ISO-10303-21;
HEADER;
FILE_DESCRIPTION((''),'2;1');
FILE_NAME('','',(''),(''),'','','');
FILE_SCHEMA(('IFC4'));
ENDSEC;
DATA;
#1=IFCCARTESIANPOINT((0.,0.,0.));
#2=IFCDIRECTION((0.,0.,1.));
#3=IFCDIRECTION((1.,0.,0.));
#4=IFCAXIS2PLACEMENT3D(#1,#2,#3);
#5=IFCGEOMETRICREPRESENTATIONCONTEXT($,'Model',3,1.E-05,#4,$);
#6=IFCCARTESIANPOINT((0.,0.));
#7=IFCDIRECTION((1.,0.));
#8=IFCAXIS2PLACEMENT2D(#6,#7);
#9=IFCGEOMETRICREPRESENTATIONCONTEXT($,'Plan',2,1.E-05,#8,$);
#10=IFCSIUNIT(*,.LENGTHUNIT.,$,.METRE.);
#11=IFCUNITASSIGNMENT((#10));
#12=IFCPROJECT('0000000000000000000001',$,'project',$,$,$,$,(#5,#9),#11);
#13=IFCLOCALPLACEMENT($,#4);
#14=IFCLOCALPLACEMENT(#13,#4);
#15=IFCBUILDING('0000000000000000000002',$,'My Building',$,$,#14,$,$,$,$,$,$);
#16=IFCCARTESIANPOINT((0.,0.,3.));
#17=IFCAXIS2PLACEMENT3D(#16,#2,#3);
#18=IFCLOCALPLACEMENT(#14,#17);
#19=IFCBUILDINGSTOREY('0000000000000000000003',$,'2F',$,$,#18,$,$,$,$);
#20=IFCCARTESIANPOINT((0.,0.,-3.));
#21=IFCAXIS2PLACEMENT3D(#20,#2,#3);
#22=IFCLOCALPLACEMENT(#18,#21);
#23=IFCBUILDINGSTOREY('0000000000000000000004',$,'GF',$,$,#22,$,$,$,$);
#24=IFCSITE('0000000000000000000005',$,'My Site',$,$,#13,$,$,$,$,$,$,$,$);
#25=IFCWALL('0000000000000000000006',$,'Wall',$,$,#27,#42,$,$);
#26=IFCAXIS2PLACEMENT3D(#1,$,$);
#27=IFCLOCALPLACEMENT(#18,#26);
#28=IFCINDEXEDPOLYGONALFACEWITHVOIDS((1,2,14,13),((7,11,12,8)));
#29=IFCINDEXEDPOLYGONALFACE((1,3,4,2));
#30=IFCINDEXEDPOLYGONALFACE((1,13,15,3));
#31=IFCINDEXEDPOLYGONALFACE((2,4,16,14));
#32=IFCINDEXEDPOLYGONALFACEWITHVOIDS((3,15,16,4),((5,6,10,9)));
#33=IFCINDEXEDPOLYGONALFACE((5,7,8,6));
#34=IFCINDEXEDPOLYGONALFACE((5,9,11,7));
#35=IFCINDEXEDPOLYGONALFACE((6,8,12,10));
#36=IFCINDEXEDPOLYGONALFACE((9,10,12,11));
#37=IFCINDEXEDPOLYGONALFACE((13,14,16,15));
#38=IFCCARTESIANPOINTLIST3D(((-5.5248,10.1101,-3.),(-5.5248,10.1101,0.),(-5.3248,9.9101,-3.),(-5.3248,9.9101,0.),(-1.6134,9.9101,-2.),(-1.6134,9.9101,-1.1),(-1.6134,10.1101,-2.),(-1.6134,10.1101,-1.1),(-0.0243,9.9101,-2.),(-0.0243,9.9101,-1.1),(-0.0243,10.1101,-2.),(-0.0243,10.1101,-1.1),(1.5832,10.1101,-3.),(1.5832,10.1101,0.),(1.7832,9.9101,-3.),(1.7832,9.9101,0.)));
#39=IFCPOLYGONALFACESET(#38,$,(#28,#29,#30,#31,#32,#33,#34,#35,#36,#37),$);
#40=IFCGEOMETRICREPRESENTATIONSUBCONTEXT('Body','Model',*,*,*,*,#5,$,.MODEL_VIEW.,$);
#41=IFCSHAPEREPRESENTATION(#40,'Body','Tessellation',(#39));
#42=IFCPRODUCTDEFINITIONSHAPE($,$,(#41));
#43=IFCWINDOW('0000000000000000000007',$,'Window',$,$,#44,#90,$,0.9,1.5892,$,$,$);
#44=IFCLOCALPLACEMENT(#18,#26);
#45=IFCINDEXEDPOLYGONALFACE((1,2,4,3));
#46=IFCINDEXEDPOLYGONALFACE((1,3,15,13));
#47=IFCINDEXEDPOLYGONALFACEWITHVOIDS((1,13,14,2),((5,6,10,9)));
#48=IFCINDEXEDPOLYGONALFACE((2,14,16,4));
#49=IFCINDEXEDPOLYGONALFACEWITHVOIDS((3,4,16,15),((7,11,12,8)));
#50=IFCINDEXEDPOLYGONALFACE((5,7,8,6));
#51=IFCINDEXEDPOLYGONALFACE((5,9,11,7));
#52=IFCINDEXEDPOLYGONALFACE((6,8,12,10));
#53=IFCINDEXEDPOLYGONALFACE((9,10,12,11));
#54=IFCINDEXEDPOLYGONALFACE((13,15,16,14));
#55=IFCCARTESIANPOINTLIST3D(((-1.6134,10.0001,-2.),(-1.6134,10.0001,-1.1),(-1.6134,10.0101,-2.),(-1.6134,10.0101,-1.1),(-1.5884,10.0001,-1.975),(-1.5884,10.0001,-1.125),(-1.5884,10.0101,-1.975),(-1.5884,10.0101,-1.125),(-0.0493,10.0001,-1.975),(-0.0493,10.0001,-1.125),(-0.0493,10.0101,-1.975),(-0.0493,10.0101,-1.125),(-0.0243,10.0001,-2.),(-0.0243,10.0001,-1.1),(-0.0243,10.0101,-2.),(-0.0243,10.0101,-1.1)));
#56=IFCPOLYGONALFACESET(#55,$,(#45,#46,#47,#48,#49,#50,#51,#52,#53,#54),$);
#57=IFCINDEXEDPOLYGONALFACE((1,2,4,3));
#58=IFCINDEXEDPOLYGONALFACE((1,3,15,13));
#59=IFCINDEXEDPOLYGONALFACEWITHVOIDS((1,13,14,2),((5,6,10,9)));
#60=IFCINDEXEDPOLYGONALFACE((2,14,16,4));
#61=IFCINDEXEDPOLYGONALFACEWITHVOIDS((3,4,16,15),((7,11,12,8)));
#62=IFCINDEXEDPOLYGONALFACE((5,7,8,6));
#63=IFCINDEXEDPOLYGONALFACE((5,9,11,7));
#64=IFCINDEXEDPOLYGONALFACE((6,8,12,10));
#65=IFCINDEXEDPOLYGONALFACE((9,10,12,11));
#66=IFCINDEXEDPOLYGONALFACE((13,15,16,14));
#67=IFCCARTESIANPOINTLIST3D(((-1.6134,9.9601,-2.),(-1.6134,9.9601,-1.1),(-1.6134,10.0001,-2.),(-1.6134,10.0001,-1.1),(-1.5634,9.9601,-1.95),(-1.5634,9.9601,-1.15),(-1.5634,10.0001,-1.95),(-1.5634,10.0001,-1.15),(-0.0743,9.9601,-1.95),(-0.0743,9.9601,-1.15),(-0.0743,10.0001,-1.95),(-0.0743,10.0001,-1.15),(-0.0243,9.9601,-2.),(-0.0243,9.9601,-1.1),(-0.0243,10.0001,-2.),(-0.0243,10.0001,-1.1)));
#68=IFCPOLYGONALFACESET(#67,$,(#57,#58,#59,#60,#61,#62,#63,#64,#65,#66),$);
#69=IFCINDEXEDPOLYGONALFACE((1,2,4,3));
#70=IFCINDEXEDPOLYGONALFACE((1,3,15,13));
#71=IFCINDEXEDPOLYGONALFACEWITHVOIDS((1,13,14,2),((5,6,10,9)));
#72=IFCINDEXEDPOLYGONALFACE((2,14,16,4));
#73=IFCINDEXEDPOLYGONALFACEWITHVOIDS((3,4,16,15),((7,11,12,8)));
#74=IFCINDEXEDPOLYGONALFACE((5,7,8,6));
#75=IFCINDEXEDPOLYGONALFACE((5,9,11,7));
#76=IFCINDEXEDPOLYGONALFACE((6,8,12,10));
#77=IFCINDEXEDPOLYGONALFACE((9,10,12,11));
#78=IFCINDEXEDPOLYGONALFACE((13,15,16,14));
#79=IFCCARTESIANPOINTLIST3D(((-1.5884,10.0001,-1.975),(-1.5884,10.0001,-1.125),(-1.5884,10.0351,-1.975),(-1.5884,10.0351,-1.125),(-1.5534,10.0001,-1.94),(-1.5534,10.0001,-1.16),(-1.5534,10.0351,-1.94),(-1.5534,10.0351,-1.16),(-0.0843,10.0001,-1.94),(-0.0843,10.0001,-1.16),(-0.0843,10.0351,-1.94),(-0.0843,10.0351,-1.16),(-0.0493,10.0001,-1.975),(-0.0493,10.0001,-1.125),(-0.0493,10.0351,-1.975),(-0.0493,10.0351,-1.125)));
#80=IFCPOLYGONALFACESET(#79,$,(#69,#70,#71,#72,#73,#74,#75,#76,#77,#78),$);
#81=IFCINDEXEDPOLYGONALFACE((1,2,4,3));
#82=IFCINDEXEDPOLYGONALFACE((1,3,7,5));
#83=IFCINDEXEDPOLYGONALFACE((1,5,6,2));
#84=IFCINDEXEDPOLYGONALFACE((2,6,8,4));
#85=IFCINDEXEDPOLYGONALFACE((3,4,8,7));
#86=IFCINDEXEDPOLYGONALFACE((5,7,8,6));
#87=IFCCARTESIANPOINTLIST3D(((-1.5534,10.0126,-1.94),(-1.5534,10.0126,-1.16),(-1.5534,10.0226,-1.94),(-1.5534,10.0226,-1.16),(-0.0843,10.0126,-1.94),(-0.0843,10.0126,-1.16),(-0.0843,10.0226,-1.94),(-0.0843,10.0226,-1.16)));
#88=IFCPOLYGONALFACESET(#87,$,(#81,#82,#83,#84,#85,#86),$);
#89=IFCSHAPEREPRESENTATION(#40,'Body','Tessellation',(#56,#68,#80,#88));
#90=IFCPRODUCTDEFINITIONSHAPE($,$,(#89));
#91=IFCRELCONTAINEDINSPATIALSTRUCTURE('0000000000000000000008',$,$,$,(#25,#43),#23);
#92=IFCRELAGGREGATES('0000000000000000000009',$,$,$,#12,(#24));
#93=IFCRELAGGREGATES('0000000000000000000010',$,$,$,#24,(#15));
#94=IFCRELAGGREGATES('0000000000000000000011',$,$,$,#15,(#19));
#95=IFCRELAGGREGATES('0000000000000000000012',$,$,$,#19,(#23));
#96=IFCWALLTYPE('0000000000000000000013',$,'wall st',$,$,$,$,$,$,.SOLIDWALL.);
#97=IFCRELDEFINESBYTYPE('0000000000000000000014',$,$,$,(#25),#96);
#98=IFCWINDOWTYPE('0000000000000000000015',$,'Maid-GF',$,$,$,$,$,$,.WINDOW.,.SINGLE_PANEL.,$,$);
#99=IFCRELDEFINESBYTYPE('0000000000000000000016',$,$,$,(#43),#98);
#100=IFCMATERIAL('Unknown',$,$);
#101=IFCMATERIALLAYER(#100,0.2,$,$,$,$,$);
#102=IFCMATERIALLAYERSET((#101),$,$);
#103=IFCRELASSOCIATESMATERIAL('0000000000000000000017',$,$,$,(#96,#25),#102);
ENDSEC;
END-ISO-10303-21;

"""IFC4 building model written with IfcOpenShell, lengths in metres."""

from ifc_helpers import new_model, entity, si_unit, frame, origin_with_axes, origin_2d_with_axis, place, context, subcontext, project, spatial, line, indexed_curve, outline, extrude, shape, source, transform, mapped, material, layer, layer_set, layer_usage, type_object, type_shapes, element, fill, save


model = new_model("IFC4")

# Units and contexts
model_context = context("Model", 3, precision=1e-05, world=origin_with_axes())
plan_context = context("Plan", 2, precision=1e-05, world=origin_2d_with_axis())
body_context_1 = subcontext(model_context, "Body", "Model", "MODEL_VIEW")
body_context_2 = subcontext(plan_context, "Body", "Plan", "PLAN_VIEW")
ifc_project = project(units=[si_unit("LENGTHUNIT", "METRE")], contexts=[model_context, plan_context])

# Site, building, storeys
site_placement = place(None, origin_with_axes())
site = spatial("IfcSite", under=ifc_project, at=site_placement, Name="My Site")
building_placement = place(site_placement, origin_with_axes())
building = spatial("IfcBuilding", under=site, at=building_placement, Name="My Building")
storey_1_placement = place(building_placement, frame((0.0, 0.0, 3.0), z_axis=(0.0, 0.0, 1.0), x_axis=(1.0, 0.0, 0.0)))
storey_1 = spatial("IfcBuildingStorey", under=building, at=storey_1_placement, Name="2F")
storey_2_placement = place(storey_1_placement, frame((0.0, 0.0, -3.0), z_axis=(0.0, 0.0, 1.0), x_axis=(1.0, 0.0, 0.0)))
storey_2 = spatial("IfcBuildingStorey", under=storey_1, at=storey_2_placement, Name="GF")

# Shared definitions
ifc_material = material(Name="Unknown")

# Shared definitions
ifc_layer = layer(ifc_material, 0.2)
ifc_layer_set = layer_set([ifc_layer])
wall_type = type_object("IfcWallType", Name="wall st", PredefinedType="SOLIDWALL", material=ifc_layer_set)

# Wall, opening, window
ifc_layer_usage_1 = layer_usage(ifc_layer_set, "AXIS2", "POSITIVE", 0.0)
wall_1_placement = place(storey_2_placement, frame((1.5832, 10.1101, 0.0), z_axis=(0.0, 0.0, 1.0), x_axis=(-1.0, 0.0, 0.0)))
wall_1 = element("IfcWall", 1, at=wall_1_placement, inside=storey_2, type_object=wall_type, material=ifc_layer_usage_1, Name="Wall", context=body_context_1, shape_type="SweptSolid", body=[
    extrude(outline(indexed_curve([(0.0, 0.0), (-0.2, 0.2), (6.908, 0.2), (7.108, 0.0)], segments=[line(1, 2, 3, 4, 1)])), origin_with_axes(), (0.0, 0.0, 1.0), 3.0),
])
shared_shape_1 = source(origin_with_axes(), body_context_1, "Body", "SweptSolid", [
    extrude(outline(indexed_curve([(0.0, 0.0), (1.5892, 0.0), (1.5892, 0.9), (0.0, 0.9)], segments=[line(1, 2, 3, 4, 1)])), frame((0.0, -0.6, 0.0), z_axis=(0.0, -1.0, 0.0), x_axis=(1.0, 0.0, 0.0)), (0.0, 0.0, -1.0), 1.2),
])
opening_1_placement = place(wall_1_placement, frame((3.1967, 0.2, 1.0), z_axis=(0.0, 0.0, 1.0), x_axis=(-1.0, 0.0, 0.0)))
opening_1 = element("IfcOpeningElement", 2, at=opening_1_placement, cuts=wall_1, PredefinedType="OPENING", context=body_context_1, shape_type="MappedRepresentation", body=[
    mapped(shared_shape_1, transform((0.0, 0.0, 0.0), x_axis=(1.0, 0.0, 0.0), y_axis=(0.0, 1.0, 0.0), z_axis=(0.0, 0.0, 1.0), scale=1.0)),
])
window_type_1 = type_object("IfcWindowType", Name="Maid-GF", PartitioningType="SINGLE_PANEL", PredefinedType="WINDOW")
shared_shape_2 = source(origin_with_axes(), body_context_1, "Body", "SweptSolid", [
    extrude(outline(indexed_curve([(0.0, 0.0), (1.5892, 0.0), (1.5892, 0.9), (0.0, 0.9)], segments=[line(1, 2, 3, 4, 1)]), holes=[indexed_curve([(0.025, 0.025), (1.5642, 0.025), (1.5642, 0.875), (0.025, 0.875)], segments=[line(1, 2, 3, 4, 1)])]), frame((0.0, 0.09, 0.0), z_axis=(0.0, -1.0, 0.0), x_axis=(1.0, 0.0, 0.0)), (0.0, 0.0, -1.0), 0.01),
    extrude(outline(indexed_curve([(0.0, 0.0), (1.5892, 0.0), (1.5892, 0.9), (0.0, 0.9)], segments=[line(1, 2, 3, 4, 1)]), holes=[indexed_curve([(0.05, 0.05), (1.5392, 0.05), (1.5392, 0.85), (0.05, 0.85)], segments=[line(1, 2, 3, 4, 1)])]), frame((0.0, 0.05, 0.0), z_axis=(0.0, -1.0, 0.0), x_axis=(1.0, 0.0, 0.0)), (0.0, 0.0, -1.0), 0.04),
    extrude(outline(indexed_curve([(0.0, 0.0), (1.5392, 0.0), (1.5392, 0.85), (0.0, 0.85)], segments=[line(1, 2, 3, 4, 1)]), holes=[indexed_curve([(0.035, 0.035), (1.5042, 0.035), (1.5042, 0.815), (0.035, 0.815)], segments=[line(1, 2, 3, 4, 1)])]), frame((0.025, 0.09, 0.025), z_axis=(0.0, -1.0, 0.0), x_axis=(1.0, 0.0, 0.0)), (0.0, 0.0, -1.0), 0.035),
    extrude(outline(indexed_curve([(0.035, 0.035), (1.5042, 0.035), (1.5042, 0.815), (0.035, 0.815)], segments=[line(1, 2, 3, 4, 1)])), frame((0.025, 0.1025, 0.025), z_axis=(0.0, -1.0, 0.0), x_axis=(1.0, 0.0, 0.0)), (0.0, 0.0, -1.0), 0.01),
])
shared_shape_3 = source(origin_with_axes(), body_context_2, "Body", "Curve2D", [
    entity("IfcIndexedPolyCurve", entity("IfcCartesianPointList2D", [[0.05, 0.05], [1.5392, 0.05]])),
    entity("IfcIndexedPolyCurve", entity("IfcCartesianPointList2D", [[0.0, 0.1], [0.025, 0.1], [0.025, 0.09], [0.05, 0.09], [0.05, 0.05], [0.0, 0.05]]), [entity("IfcLineIndex", [1, 2, 3, 4, 5, 6, 1])]),
    entity("IfcIndexedPolyCurve", entity("IfcCartesianPointList2D", [[1.5892, 0.1], [1.5642, 0.1], [1.5642, 0.09], [1.5392, 0.09], [1.5392, 0.05], [1.5892, 0.05]]), [entity("IfcLineIndex", [1, 2, 3, 4, 5, 6, 1])]),
    entity("IfcIndexedPolyCurve", entity("IfcCartesianPointList2D", [[0.025, 0.09], [0.06, 0.09], [0.06, 0.125], [0.025, 0.125]]), [entity("IfcLineIndex", [1, 2, 3, 4, 1])]),
    entity("IfcIndexedPolyCurve", entity("IfcCartesianPointList2D", [[1.5642, 0.09], [1.5292, 0.09], [1.5292, 0.125], [1.5642, 0.125]]), [entity("IfcLineIndex", [1, 2, 3, 4, 1])]),
    entity("IfcIndexedPolyCurve", entity("IfcCartesianPointList2D", [[0.06, 0.09], [1.5292, 0.09]])),
    entity("IfcIndexedPolyCurve", entity("IfcCartesianPointList2D", [[0.06, 0.125], [1.5292, 0.125]])),
    entity("IfcIndexedPolyCurve", entity("IfcCartesianPointList2D", [[0.06, 0.1075], [1.5292, 0.1075]])),
])
type_shapes(window_type_1, [shared_shape_2, shared_shape_3])
window_1_placement = place(opening_1_placement, frame((0.0, 0.0, 0.0), z_axis=(0.0, 0.0, 1.0), x_axis=(1.0, 0.0, 0.0)))
window_1 = element("IfcWindow", 3, at=window_1_placement, inside=storey_2, type_object=window_type_1, Name="Window", OverallHeight=0.9, OverallWidth=1.5892, shapes=[
    shape(body_context_1, "Body", "MappedRepresentation", [mapped(shared_shape_2, transform((0.0, 0.0, 0.0), x_axis=(1.0, 0.0, 0.0), y_axis=(0.0, 1.0, 0.0), z_axis=(0.0, 0.0, 1.0), scale=1.0))]),
    shape(body_context_2, "Body", "MappedRepresentation", [mapped(shared_shape_3, transform((0.0, 0.0, 0.0), x_axis=(1.0, 0.0, 0.0), y_axis=(0.0, 1.0, 0.0), z_axis=(0.0, 0.0, 1.0), scale=1.0))]),
])
fill(opening_1, window_1)

save(model, "model.ifc")
